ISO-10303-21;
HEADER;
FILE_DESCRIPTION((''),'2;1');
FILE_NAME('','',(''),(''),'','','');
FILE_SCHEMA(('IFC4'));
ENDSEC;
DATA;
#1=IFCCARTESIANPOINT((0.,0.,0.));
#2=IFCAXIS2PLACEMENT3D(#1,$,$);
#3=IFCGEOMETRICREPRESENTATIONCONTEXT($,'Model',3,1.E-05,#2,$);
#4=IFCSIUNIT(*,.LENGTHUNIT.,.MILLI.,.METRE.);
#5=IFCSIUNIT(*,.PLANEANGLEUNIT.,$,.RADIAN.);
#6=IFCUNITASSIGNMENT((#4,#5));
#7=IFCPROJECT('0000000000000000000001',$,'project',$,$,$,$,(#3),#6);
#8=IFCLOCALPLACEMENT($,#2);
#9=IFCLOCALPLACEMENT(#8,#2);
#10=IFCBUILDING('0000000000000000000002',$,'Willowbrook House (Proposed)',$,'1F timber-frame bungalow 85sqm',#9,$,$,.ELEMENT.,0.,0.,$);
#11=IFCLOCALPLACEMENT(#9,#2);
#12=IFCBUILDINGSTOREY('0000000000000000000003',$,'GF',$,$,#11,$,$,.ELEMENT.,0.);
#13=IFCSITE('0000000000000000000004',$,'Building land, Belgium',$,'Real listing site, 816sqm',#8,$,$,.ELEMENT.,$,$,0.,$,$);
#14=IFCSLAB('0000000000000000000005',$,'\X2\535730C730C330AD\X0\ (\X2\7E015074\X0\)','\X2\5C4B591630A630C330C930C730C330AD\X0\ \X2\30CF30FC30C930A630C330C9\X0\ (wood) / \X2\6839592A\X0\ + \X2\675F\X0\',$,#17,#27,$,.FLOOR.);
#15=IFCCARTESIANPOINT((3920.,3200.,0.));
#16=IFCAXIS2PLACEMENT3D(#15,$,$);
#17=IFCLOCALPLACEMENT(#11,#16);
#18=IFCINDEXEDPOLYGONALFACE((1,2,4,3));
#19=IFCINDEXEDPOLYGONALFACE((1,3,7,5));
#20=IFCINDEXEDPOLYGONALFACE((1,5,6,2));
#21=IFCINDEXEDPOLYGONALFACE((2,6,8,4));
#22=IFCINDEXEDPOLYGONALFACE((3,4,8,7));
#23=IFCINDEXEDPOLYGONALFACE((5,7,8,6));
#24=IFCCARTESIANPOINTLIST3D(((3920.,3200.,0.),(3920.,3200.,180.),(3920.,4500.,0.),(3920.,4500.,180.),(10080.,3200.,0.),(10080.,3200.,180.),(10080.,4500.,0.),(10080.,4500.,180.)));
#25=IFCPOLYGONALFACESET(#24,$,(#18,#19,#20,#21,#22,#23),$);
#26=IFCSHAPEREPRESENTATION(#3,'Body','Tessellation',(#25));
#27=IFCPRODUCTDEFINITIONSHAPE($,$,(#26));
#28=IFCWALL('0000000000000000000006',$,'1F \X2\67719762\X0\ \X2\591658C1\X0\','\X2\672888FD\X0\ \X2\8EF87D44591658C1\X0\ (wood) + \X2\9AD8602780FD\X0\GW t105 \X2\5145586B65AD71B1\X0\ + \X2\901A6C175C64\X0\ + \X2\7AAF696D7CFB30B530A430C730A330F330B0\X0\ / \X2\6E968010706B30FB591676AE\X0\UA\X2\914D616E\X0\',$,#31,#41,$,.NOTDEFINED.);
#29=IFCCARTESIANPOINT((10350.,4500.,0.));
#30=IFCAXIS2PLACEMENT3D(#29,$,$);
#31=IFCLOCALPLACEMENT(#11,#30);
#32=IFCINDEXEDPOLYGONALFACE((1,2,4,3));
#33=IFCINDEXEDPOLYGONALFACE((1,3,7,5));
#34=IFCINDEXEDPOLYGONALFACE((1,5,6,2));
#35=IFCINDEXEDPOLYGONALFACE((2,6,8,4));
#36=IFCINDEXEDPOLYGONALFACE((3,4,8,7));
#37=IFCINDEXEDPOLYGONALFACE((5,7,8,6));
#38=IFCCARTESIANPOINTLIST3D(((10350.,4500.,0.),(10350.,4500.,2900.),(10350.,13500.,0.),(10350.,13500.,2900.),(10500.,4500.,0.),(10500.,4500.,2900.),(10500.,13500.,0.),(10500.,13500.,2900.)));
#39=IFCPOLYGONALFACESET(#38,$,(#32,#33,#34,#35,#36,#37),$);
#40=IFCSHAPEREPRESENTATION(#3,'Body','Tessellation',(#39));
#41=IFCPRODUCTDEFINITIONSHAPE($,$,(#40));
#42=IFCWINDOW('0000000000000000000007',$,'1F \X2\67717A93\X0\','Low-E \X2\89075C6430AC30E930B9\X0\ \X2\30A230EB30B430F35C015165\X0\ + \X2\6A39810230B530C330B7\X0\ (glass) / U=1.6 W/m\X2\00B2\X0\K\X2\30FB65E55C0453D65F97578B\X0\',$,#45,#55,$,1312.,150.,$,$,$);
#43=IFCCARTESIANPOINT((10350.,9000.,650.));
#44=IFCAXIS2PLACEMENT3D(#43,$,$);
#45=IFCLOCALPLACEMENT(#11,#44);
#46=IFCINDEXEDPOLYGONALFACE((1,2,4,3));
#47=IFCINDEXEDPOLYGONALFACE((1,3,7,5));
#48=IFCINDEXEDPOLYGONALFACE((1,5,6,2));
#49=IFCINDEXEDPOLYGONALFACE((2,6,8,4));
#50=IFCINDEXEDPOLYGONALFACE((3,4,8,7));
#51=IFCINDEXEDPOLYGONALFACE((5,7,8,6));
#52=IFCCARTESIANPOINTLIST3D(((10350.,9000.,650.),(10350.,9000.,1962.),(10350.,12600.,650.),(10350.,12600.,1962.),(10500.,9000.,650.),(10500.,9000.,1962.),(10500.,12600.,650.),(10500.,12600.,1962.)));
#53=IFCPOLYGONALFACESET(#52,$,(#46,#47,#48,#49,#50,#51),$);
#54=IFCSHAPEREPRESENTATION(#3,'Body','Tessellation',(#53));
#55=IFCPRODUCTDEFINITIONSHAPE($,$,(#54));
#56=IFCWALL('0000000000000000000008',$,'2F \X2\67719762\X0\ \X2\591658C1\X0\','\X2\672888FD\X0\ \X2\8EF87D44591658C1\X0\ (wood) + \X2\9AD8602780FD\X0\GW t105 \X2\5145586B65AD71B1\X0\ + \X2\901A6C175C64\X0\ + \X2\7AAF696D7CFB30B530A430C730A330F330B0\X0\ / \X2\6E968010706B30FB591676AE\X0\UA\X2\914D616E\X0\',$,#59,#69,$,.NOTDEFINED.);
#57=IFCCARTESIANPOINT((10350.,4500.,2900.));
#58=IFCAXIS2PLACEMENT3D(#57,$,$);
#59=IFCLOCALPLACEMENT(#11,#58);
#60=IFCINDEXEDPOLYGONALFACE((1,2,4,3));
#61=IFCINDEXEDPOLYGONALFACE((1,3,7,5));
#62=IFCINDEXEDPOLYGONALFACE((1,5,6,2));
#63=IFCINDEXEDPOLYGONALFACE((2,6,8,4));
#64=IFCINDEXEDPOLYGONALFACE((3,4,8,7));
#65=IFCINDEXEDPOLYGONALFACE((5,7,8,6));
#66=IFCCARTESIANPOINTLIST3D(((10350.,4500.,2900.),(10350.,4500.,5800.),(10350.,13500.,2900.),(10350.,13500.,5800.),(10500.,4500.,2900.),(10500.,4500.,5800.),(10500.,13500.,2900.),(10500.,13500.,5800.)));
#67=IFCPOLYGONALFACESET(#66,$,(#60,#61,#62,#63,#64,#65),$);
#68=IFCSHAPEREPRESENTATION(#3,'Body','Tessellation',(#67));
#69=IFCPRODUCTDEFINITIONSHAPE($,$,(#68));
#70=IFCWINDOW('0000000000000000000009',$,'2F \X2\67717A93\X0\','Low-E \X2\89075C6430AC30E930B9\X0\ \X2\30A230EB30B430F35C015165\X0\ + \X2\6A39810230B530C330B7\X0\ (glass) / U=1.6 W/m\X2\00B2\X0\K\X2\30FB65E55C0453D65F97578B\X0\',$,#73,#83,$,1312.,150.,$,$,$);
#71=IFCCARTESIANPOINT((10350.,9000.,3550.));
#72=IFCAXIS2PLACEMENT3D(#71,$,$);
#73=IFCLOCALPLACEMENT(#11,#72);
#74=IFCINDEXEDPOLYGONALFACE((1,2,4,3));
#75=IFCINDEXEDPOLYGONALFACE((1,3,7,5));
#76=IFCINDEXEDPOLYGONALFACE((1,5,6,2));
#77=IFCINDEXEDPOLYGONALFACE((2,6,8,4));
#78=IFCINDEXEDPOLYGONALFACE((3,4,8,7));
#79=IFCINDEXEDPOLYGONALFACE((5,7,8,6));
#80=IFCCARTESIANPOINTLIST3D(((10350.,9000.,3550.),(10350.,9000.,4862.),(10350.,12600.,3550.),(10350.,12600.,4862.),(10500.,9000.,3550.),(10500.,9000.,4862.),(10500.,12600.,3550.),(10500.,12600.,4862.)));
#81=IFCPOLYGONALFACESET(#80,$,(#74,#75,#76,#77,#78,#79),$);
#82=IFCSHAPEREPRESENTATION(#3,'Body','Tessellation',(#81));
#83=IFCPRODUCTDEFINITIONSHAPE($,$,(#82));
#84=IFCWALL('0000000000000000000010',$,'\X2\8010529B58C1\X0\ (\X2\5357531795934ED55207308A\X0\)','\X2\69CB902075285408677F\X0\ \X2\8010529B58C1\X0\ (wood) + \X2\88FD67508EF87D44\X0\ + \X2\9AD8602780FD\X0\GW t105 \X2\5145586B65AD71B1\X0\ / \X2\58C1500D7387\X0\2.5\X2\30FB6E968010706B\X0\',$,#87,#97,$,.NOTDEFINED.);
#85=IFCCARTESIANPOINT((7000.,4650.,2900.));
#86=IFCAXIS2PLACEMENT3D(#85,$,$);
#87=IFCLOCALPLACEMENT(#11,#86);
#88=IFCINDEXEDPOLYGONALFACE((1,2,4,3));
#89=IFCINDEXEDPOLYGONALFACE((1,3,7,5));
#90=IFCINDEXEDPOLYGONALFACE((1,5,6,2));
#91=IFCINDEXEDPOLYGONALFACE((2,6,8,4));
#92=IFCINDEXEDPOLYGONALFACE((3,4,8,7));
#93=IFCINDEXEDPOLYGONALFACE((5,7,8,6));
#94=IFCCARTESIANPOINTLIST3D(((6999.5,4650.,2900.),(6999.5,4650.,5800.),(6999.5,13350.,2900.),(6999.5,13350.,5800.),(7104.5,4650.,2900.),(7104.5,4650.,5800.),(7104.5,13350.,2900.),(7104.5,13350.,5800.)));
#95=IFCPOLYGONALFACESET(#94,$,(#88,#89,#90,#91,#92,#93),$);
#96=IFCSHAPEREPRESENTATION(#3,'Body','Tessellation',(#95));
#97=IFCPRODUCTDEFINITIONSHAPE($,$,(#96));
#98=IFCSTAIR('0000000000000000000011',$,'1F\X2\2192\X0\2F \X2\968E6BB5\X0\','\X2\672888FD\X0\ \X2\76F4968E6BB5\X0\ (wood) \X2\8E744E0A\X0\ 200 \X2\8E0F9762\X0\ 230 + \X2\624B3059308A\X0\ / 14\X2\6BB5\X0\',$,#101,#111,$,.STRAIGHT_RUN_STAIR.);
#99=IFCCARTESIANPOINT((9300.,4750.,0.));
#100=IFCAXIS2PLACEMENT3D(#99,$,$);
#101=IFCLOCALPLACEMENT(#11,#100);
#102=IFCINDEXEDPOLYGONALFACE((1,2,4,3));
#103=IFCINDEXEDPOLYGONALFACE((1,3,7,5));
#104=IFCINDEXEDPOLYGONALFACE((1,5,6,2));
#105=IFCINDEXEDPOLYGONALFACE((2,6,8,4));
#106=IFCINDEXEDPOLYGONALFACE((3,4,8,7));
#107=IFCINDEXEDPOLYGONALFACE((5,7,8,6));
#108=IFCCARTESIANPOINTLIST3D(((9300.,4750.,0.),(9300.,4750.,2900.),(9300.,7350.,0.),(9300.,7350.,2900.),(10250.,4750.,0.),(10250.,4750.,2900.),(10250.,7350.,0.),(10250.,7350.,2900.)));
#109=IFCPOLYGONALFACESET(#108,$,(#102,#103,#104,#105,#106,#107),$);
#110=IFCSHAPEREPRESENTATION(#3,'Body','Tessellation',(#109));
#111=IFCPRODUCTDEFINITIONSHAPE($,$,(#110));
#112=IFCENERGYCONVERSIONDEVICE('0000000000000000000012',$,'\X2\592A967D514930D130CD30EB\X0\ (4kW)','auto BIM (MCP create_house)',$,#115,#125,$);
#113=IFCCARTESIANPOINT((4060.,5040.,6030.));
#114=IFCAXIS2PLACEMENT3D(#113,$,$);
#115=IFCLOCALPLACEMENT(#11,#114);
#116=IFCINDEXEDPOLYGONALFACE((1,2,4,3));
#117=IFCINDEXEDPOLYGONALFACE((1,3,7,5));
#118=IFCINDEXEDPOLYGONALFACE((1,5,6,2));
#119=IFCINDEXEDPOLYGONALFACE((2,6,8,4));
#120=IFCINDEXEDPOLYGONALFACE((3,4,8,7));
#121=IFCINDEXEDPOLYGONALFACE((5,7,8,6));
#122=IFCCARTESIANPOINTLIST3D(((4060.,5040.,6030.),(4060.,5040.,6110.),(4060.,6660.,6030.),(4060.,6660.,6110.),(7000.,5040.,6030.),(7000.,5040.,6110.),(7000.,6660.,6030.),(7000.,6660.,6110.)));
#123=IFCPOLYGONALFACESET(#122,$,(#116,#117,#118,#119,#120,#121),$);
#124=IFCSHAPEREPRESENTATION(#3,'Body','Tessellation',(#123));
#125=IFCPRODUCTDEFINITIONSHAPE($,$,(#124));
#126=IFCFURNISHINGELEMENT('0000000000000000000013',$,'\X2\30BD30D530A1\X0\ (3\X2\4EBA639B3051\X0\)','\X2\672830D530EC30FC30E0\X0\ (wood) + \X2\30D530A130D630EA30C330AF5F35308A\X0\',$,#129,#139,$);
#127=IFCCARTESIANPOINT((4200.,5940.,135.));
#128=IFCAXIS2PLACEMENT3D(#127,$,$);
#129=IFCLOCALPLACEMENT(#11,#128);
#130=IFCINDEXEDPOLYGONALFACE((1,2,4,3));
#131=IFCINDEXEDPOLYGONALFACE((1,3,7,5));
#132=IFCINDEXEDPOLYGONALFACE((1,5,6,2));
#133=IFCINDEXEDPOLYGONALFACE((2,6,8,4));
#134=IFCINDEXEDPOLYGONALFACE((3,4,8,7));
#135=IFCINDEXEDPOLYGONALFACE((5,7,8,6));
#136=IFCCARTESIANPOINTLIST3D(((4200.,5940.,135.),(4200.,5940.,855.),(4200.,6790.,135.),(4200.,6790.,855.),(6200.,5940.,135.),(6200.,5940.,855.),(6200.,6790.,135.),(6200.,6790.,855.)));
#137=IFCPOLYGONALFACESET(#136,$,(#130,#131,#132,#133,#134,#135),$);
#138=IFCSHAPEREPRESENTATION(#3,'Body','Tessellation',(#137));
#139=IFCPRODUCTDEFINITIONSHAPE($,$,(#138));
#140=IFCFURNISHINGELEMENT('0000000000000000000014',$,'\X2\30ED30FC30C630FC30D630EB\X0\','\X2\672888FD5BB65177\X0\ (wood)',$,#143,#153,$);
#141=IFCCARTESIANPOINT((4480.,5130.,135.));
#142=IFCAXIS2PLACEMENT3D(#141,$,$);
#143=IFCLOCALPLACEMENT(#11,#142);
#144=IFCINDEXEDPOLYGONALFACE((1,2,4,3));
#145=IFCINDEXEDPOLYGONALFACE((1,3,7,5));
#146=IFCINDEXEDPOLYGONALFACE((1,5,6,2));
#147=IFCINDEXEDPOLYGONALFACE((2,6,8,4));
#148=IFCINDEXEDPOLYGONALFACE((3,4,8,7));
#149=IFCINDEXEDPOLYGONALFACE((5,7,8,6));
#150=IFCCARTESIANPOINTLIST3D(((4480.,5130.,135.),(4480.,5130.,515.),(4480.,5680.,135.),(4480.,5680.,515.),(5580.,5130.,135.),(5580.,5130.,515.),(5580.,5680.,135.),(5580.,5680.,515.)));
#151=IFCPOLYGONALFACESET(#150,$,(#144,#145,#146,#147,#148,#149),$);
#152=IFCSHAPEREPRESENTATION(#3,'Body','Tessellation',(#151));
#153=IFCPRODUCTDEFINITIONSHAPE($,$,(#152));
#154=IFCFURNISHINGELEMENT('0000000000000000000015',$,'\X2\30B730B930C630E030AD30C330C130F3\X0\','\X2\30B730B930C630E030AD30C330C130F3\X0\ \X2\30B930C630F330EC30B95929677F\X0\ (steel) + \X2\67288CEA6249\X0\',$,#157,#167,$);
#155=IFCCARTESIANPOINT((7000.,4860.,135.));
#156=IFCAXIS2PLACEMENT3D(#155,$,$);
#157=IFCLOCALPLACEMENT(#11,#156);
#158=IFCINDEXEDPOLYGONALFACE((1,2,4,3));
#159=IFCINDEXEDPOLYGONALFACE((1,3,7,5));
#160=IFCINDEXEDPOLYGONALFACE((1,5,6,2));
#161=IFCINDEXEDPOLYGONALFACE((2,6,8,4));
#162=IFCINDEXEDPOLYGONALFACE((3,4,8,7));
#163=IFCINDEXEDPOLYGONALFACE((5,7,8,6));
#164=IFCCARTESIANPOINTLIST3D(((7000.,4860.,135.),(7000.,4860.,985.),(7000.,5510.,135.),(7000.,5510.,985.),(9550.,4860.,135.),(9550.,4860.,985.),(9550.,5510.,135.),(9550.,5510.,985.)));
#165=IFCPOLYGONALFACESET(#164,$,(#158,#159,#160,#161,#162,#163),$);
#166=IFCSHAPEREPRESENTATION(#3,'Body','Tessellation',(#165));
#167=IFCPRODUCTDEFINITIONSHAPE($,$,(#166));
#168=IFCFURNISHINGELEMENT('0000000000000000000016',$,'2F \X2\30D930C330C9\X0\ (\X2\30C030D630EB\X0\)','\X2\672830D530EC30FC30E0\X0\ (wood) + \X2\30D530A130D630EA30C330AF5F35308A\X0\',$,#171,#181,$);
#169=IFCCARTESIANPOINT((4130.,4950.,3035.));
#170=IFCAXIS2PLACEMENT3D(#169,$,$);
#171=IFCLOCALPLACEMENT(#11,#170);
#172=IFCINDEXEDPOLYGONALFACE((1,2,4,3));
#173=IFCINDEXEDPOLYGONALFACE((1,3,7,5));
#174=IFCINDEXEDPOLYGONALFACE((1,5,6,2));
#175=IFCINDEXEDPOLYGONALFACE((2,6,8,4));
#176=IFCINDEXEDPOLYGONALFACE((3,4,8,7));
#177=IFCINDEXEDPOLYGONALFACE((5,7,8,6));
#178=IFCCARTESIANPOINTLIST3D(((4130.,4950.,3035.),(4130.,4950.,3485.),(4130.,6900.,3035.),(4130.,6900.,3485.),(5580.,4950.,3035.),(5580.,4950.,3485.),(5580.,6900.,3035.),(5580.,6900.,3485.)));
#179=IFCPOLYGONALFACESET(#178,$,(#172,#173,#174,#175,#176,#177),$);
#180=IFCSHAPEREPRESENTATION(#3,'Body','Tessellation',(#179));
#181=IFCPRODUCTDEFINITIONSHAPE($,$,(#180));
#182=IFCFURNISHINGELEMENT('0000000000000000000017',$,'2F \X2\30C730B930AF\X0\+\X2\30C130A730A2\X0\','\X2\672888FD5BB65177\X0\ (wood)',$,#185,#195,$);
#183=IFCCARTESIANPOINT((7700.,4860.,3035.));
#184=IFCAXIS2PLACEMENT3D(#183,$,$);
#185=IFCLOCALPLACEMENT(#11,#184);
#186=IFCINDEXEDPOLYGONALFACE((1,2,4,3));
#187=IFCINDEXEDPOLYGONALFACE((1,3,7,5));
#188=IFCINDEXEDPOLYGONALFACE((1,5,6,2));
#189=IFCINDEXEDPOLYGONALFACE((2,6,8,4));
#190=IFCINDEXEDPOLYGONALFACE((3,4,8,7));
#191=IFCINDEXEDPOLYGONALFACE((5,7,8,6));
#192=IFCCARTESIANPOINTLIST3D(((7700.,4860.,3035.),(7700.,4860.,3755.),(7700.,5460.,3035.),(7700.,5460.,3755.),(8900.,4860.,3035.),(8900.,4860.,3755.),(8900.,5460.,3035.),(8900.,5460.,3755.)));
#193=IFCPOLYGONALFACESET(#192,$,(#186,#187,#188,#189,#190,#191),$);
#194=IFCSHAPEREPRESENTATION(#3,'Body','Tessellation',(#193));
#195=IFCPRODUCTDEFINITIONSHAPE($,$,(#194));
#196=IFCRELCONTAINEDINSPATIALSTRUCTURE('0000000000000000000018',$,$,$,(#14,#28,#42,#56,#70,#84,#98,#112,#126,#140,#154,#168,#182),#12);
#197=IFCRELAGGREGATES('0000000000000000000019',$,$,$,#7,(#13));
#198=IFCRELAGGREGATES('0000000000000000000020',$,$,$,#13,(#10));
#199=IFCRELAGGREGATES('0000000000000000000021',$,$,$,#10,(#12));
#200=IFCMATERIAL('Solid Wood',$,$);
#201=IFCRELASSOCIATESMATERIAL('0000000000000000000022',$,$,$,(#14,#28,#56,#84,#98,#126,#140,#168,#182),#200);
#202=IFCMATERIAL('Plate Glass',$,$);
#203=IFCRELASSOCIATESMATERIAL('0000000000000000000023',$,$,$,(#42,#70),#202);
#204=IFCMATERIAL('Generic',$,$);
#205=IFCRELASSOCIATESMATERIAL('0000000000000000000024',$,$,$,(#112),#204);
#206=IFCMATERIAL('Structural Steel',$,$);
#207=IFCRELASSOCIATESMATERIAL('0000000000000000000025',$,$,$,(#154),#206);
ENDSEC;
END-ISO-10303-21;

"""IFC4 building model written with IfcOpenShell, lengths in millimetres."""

from ifc_helpers import new_model, si_unit, frame, frame_2d, origin, place, context, project, spatial, rectangle, extrude, material, element, fill, save


model = new_model("IFC4")

# Units and contexts
model_context = context("Model", 3, precision=1e-05, world=origin())
ifc_project = project(units=[si_unit("LENGTHUNIT", "METRE", prefix="MILLI"), si_unit("PLANEANGLEUNIT", "RADIAN")], contexts=[model_context])

# Site, building, storey
site_placement = place(None, origin())
site = spatial("IfcSite", under=ifc_project, at=site_placement, Name="Building land, Belgium", ObjectType="Real listing site, 816sqm", CompositionType="ELEMENT", RefElevation=0.0)
building_placement = place(site_placement, origin())
building = spatial("IfcBuilding", under=site, at=building_placement, Name="Willowbrook House (Proposed)", ObjectType="1F timber-frame bungalow 85sqm", CompositionType="ELEMENT", ElevationOfRefHeight=0.0, ElevationOfTerrain=0.0)
storey_placement = place(building_placement, origin())
storey = spatial("IfcBuildingStorey", under=building, at=storey_placement, Name="GF", CompositionType="ELEMENT", Elevation=0.0)

# Slab
ifc_material_1 = material(Name="Solid Wood")
slab_placement = place(storey_placement, frame((3920.0, 3200.0, 0.0)))
element("IfcSlab", 1, at=slab_placement, inside=storey, material=ifc_material_1, Name="南デッキ (縁側)", Description="屋外ウッドデッキ ハードウッド (wood) / 根太 + 束", PredefinedType="FLOOR", context=model_context, shape_type="SweptSolid", body=[
    extrude(rectangle(XDim=6160.0, YDim=1300.0, at=frame_2d((3080.0, 650.0))), frame((3920.0, 3200.0, 0.0)), (0.0, 0.0, 1.0), 180.0),
])

# Wall, opening, window
wall_1_placement = place(storey_placement, frame((10350.0, 4500.0, 0.0)))
wall_1 = element("IfcWall", 2, at=wall_1_placement, inside=storey, material=ifc_material_1, Name="1F 東面 外壁", Description="木製 軸組外壁 (wood) + 高性能GW t105 充填断熱 + 通気層 + 窯業系サイディング / 準耐火・外皮UA配慮", PredefinedType="NOTDEFINED", context=model_context, shape_type="SweptSolid", body=[
    extrude(rectangle(XDim=150.0, YDim=9000.0, at=frame_2d((75.0, 4500.0))), frame((10350.0, 4500.0, 0.0)), (0.0, 0.0, 1.0), 2900.0),
])
opening_1_placement = place(storey_placement, frame((10350.0, 9000.0, 650.0)))
opening_1 = element("IfcOpeningElement", 3, at=opening_1_placement, cuts=wall_1, PredefinedType="NOTDEFINED", context=model_context, shape_type="SweptSolid", body=[
    extrude(rectangle(XDim=150.0, YDim=3600.0, at=frame_2d((75.0, 1800.0))), frame((10350.0, 9000.0, 650.0)), (0.0, 0.0, 1.0), 1312.0),
])
ifc_material_2 = material(Name="Plate Glass")
window_1_placement = place(storey_placement, frame((10350.0, 9000.0, 650.0)))
window_1 = element("IfcWindow", 4, at=window_1_placement, inside=storey, material=ifc_material_2, Name="1F 東窓", Description="Low-E 複層ガラス アルゴン封入 + 樹脂サッシ (glass) / U=1.6 W/m²K・日射取得型", OverallHeight=1312.0, OverallWidth=150.0, context=model_context, shape_type="SweptSolid", body=[
    extrude(rectangle(XDim=150.0, YDim=3600.0, at=frame_2d((75.0, 1800.0))), frame((10350.0, 9000.0, 650.0)), (0.0, 0.0, 1.0), 1312.0),
])
fill(opening_1, window_1)

# Wall, opening, window
wall_2_placement = place(storey_placement, frame((10350.0, 4500.0, 2900.0)))
wall_2 = element("IfcWall", 5, at=wall_2_placement, inside=storey, material=ifc_material_1, Name="2F 東面 外壁", Description="木製 軸組外壁 (wood) + 高性能GW t105 充填断熱 + 通気層 + 窯業系サイディング / 準耐火・外皮UA配慮", PredefinedType="NOTDEFINED", context=model_context, shape_type="SweptSolid", body=[
    extrude(rectangle(XDim=150.0, YDim=9000.0, at=frame_2d((75.0, 4500.0))), frame((10350.0, 4500.0, 2900.0)), (0.0, 0.0, 1.0), 2900.0),
])
opening_2_placement = place(storey_placement, frame((10350.0, 9000.0, 3550.0)))
opening_2 = element("IfcOpeningElement", 6, at=opening_2_placement, cuts=wall_2, PredefinedType="NOTDEFINED", context=model_context, shape_type="SweptSolid", body=[
    extrude(rectangle(XDim=150.0, YDim=3600.0, at=frame_2d((75.0, 1800.0))), frame((10350.0, 9000.0, 3550.0)), (0.0, 0.0, 1.0), 1312.0),
])
window_2_placement = place(storey_placement, frame((10350.0, 9000.0, 3550.0)))
window_2 = element("IfcWindow", 7, at=window_2_placement, inside=storey, material=ifc_material_2, Name="2F 東窓", Description="Low-E 複層ガラス アルゴン封入 + 樹脂サッシ (glass) / U=1.6 W/m²K・日射取得型", OverallHeight=1312.0, OverallWidth=150.0, context=model_context, shape_type="SweptSolid", body=[
    extrude(rectangle(XDim=150.0, YDim=3600.0, at=frame_2d((75.0, 1800.0))), frame((10350.0, 9000.0, 3550.0)), (0.0, 0.0, 1.0), 1312.0),
])
fill(opening_2, window_2)

# Wall
wall_3_placement = place(storey_placement, frame((7000.0, 4650.0, 2900.0)))
element("IfcWall", 8, at=wall_3_placement, inside=storey, material=ifc_material_1, Name="耐力壁 (南北間仕切り)", Description="構造用合板 耐力壁 (wood) + 製材軸組 + 高性能GW t105 充填断熱 / 壁倍率2.5・準耐火", PredefinedType="NOTDEFINED", context=model_context, shape_type="SweptSolid", body=[
    extrude(rectangle(XDim=105.0, YDim=8700.0, at=frame_2d((52.0, 4350.0))), frame((7000.0, 4650.0, 2900.0)), (0.0, 0.0, 1.0), 2900.0),
])

# Stair
stair_placement = place(storey_placement, frame((9300.0, 4750.0, 0.0)))
element("IfcStair", 9, at=stair_placement, inside=storey, material=ifc_material_1, Name="1F→2F 階段", Description="木製 直階段 (wood) 蹴上 200 踏面 230 + 手すり / 14段", PredefinedType="STRAIGHT_RUN_STAIR", context=model_context, shape_type="SweptSolid", body=[
    extrude(rectangle(XDim=950.0, YDim=2600.0, at=frame_2d((475.0, 1300.0))), frame((9300.0, 4750.0, 0.0)), (0.0, 0.0, 1.0), 2900.0),
])

# Energy conversion device
ifc_material_3 = material(Name="Generic")
energy_conversion_device_placement = place(storey_placement, frame((4060.0, 5040.0, 6030.0)))
element("IfcEnergyConversionDevice", 10, at=energy_conversion_device_placement, inside=storey, material=ifc_material_3, Name="太陽光パネル (4kW)", Description="auto BIM (MCP create_house)", context=model_context, shape_type="SweptSolid", body=[
    extrude(rectangle(XDim=2940.0, YDim=1620.0, at=frame_2d((1470.0, 810.0))), frame((4060.0, 5040.0, 6030.0)), (0.0, 0.0, 1.0), 80.0),
])

# Furnishing elements
furnishing_1_placement = place(storey_placement, frame((4200.0, 5940.0, 135.0)))
element("IfcFurnishingElement", 11, at=furnishing_1_placement, inside=storey, material=ifc_material_1, Name="ソファ (3人掛け)", Description="木フレーム (wood) + ファブリック張り", context=model_context, shape_type="SweptSolid", body=[
    extrude(rectangle(XDim=2000.0, YDim=850.0, at=frame_2d((1000.0, 425.0))), frame((4200.0, 5940.0, 135.0)), (0.0, 0.0, 1.0), 720.0),
])
furnishing_2_placement = place(storey_placement, frame((4480.0, 5130.0, 135.0)))
element("IfcFurnishingElement", 12, at=furnishing_2_placement, inside=storey, material=ifc_material_1, Name="ローテーブル", Description="木製家具 (wood)", context=model_context, shape_type="SweptSolid", body=[
    extrude(rectangle(XDim=1100.0, YDim=550.0, at=frame_2d((550.0, 275.0))), frame((4480.0, 5130.0, 135.0)), (0.0, 0.0, 1.0), 380.0),
])
ifc_material_4 = material(Name="Structural Steel")
furnishing_3_placement = place(storey_placement, frame((7000.0, 4860.0, 135.0)))
element("IfcFurnishingElement", 13, at=furnishing_3_placement, inside=storey, material=ifc_material_4, Name="システムキッチン", Description="システムキッチン ステンレス天板 (steel) + 木質扉", context=model_context, shape_type="SweptSolid", body=[
    extrude(rectangle(XDim=2550.0, YDim=650.0, at=frame_2d((1275.0, 325.0))), frame((7000.0, 4860.0, 135.0)), (0.0, 0.0, 1.0), 850.0),
])
furnishing_4_placement = place(storey_placement, frame((4130.0, 4950.0, 3035.0)))
element("IfcFurnishingElement", 14, at=furnishing_4_placement, inside=storey, material=ifc_material_1, Name="2F ベッド (ダブル)", Description="木フレーム (wood) + ファブリック張り", context=model_context, shape_type="SweptSolid", body=[
    extrude(rectangle(XDim=1450.0, YDim=1950.0, at=frame_2d((725.0, 975.0))), frame((4130.0, 4950.0, 3035.0)), (0.0, 0.0, 1.0), 450.0),
])
furnishing_5_placement = place(storey_placement, frame((7700.0, 4860.0, 3035.0)))
element("IfcFurnishingElement", 15, at=furnishing_5_placement, inside=storey, material=ifc_material_1, Name="2F デスク+チェア", Description="木製家具 (wood)", context=model_context, shape_type="SweptSolid", body=[
    extrude(rectangle(XDim=1200.0, YDim=600.0, at=frame_2d((600.0, 300.0))), frame((7700.0, 4860.0, 3035.0)), (0.0, 0.0, 1.0), 720.0),
])

save(model, "model.ifc")
